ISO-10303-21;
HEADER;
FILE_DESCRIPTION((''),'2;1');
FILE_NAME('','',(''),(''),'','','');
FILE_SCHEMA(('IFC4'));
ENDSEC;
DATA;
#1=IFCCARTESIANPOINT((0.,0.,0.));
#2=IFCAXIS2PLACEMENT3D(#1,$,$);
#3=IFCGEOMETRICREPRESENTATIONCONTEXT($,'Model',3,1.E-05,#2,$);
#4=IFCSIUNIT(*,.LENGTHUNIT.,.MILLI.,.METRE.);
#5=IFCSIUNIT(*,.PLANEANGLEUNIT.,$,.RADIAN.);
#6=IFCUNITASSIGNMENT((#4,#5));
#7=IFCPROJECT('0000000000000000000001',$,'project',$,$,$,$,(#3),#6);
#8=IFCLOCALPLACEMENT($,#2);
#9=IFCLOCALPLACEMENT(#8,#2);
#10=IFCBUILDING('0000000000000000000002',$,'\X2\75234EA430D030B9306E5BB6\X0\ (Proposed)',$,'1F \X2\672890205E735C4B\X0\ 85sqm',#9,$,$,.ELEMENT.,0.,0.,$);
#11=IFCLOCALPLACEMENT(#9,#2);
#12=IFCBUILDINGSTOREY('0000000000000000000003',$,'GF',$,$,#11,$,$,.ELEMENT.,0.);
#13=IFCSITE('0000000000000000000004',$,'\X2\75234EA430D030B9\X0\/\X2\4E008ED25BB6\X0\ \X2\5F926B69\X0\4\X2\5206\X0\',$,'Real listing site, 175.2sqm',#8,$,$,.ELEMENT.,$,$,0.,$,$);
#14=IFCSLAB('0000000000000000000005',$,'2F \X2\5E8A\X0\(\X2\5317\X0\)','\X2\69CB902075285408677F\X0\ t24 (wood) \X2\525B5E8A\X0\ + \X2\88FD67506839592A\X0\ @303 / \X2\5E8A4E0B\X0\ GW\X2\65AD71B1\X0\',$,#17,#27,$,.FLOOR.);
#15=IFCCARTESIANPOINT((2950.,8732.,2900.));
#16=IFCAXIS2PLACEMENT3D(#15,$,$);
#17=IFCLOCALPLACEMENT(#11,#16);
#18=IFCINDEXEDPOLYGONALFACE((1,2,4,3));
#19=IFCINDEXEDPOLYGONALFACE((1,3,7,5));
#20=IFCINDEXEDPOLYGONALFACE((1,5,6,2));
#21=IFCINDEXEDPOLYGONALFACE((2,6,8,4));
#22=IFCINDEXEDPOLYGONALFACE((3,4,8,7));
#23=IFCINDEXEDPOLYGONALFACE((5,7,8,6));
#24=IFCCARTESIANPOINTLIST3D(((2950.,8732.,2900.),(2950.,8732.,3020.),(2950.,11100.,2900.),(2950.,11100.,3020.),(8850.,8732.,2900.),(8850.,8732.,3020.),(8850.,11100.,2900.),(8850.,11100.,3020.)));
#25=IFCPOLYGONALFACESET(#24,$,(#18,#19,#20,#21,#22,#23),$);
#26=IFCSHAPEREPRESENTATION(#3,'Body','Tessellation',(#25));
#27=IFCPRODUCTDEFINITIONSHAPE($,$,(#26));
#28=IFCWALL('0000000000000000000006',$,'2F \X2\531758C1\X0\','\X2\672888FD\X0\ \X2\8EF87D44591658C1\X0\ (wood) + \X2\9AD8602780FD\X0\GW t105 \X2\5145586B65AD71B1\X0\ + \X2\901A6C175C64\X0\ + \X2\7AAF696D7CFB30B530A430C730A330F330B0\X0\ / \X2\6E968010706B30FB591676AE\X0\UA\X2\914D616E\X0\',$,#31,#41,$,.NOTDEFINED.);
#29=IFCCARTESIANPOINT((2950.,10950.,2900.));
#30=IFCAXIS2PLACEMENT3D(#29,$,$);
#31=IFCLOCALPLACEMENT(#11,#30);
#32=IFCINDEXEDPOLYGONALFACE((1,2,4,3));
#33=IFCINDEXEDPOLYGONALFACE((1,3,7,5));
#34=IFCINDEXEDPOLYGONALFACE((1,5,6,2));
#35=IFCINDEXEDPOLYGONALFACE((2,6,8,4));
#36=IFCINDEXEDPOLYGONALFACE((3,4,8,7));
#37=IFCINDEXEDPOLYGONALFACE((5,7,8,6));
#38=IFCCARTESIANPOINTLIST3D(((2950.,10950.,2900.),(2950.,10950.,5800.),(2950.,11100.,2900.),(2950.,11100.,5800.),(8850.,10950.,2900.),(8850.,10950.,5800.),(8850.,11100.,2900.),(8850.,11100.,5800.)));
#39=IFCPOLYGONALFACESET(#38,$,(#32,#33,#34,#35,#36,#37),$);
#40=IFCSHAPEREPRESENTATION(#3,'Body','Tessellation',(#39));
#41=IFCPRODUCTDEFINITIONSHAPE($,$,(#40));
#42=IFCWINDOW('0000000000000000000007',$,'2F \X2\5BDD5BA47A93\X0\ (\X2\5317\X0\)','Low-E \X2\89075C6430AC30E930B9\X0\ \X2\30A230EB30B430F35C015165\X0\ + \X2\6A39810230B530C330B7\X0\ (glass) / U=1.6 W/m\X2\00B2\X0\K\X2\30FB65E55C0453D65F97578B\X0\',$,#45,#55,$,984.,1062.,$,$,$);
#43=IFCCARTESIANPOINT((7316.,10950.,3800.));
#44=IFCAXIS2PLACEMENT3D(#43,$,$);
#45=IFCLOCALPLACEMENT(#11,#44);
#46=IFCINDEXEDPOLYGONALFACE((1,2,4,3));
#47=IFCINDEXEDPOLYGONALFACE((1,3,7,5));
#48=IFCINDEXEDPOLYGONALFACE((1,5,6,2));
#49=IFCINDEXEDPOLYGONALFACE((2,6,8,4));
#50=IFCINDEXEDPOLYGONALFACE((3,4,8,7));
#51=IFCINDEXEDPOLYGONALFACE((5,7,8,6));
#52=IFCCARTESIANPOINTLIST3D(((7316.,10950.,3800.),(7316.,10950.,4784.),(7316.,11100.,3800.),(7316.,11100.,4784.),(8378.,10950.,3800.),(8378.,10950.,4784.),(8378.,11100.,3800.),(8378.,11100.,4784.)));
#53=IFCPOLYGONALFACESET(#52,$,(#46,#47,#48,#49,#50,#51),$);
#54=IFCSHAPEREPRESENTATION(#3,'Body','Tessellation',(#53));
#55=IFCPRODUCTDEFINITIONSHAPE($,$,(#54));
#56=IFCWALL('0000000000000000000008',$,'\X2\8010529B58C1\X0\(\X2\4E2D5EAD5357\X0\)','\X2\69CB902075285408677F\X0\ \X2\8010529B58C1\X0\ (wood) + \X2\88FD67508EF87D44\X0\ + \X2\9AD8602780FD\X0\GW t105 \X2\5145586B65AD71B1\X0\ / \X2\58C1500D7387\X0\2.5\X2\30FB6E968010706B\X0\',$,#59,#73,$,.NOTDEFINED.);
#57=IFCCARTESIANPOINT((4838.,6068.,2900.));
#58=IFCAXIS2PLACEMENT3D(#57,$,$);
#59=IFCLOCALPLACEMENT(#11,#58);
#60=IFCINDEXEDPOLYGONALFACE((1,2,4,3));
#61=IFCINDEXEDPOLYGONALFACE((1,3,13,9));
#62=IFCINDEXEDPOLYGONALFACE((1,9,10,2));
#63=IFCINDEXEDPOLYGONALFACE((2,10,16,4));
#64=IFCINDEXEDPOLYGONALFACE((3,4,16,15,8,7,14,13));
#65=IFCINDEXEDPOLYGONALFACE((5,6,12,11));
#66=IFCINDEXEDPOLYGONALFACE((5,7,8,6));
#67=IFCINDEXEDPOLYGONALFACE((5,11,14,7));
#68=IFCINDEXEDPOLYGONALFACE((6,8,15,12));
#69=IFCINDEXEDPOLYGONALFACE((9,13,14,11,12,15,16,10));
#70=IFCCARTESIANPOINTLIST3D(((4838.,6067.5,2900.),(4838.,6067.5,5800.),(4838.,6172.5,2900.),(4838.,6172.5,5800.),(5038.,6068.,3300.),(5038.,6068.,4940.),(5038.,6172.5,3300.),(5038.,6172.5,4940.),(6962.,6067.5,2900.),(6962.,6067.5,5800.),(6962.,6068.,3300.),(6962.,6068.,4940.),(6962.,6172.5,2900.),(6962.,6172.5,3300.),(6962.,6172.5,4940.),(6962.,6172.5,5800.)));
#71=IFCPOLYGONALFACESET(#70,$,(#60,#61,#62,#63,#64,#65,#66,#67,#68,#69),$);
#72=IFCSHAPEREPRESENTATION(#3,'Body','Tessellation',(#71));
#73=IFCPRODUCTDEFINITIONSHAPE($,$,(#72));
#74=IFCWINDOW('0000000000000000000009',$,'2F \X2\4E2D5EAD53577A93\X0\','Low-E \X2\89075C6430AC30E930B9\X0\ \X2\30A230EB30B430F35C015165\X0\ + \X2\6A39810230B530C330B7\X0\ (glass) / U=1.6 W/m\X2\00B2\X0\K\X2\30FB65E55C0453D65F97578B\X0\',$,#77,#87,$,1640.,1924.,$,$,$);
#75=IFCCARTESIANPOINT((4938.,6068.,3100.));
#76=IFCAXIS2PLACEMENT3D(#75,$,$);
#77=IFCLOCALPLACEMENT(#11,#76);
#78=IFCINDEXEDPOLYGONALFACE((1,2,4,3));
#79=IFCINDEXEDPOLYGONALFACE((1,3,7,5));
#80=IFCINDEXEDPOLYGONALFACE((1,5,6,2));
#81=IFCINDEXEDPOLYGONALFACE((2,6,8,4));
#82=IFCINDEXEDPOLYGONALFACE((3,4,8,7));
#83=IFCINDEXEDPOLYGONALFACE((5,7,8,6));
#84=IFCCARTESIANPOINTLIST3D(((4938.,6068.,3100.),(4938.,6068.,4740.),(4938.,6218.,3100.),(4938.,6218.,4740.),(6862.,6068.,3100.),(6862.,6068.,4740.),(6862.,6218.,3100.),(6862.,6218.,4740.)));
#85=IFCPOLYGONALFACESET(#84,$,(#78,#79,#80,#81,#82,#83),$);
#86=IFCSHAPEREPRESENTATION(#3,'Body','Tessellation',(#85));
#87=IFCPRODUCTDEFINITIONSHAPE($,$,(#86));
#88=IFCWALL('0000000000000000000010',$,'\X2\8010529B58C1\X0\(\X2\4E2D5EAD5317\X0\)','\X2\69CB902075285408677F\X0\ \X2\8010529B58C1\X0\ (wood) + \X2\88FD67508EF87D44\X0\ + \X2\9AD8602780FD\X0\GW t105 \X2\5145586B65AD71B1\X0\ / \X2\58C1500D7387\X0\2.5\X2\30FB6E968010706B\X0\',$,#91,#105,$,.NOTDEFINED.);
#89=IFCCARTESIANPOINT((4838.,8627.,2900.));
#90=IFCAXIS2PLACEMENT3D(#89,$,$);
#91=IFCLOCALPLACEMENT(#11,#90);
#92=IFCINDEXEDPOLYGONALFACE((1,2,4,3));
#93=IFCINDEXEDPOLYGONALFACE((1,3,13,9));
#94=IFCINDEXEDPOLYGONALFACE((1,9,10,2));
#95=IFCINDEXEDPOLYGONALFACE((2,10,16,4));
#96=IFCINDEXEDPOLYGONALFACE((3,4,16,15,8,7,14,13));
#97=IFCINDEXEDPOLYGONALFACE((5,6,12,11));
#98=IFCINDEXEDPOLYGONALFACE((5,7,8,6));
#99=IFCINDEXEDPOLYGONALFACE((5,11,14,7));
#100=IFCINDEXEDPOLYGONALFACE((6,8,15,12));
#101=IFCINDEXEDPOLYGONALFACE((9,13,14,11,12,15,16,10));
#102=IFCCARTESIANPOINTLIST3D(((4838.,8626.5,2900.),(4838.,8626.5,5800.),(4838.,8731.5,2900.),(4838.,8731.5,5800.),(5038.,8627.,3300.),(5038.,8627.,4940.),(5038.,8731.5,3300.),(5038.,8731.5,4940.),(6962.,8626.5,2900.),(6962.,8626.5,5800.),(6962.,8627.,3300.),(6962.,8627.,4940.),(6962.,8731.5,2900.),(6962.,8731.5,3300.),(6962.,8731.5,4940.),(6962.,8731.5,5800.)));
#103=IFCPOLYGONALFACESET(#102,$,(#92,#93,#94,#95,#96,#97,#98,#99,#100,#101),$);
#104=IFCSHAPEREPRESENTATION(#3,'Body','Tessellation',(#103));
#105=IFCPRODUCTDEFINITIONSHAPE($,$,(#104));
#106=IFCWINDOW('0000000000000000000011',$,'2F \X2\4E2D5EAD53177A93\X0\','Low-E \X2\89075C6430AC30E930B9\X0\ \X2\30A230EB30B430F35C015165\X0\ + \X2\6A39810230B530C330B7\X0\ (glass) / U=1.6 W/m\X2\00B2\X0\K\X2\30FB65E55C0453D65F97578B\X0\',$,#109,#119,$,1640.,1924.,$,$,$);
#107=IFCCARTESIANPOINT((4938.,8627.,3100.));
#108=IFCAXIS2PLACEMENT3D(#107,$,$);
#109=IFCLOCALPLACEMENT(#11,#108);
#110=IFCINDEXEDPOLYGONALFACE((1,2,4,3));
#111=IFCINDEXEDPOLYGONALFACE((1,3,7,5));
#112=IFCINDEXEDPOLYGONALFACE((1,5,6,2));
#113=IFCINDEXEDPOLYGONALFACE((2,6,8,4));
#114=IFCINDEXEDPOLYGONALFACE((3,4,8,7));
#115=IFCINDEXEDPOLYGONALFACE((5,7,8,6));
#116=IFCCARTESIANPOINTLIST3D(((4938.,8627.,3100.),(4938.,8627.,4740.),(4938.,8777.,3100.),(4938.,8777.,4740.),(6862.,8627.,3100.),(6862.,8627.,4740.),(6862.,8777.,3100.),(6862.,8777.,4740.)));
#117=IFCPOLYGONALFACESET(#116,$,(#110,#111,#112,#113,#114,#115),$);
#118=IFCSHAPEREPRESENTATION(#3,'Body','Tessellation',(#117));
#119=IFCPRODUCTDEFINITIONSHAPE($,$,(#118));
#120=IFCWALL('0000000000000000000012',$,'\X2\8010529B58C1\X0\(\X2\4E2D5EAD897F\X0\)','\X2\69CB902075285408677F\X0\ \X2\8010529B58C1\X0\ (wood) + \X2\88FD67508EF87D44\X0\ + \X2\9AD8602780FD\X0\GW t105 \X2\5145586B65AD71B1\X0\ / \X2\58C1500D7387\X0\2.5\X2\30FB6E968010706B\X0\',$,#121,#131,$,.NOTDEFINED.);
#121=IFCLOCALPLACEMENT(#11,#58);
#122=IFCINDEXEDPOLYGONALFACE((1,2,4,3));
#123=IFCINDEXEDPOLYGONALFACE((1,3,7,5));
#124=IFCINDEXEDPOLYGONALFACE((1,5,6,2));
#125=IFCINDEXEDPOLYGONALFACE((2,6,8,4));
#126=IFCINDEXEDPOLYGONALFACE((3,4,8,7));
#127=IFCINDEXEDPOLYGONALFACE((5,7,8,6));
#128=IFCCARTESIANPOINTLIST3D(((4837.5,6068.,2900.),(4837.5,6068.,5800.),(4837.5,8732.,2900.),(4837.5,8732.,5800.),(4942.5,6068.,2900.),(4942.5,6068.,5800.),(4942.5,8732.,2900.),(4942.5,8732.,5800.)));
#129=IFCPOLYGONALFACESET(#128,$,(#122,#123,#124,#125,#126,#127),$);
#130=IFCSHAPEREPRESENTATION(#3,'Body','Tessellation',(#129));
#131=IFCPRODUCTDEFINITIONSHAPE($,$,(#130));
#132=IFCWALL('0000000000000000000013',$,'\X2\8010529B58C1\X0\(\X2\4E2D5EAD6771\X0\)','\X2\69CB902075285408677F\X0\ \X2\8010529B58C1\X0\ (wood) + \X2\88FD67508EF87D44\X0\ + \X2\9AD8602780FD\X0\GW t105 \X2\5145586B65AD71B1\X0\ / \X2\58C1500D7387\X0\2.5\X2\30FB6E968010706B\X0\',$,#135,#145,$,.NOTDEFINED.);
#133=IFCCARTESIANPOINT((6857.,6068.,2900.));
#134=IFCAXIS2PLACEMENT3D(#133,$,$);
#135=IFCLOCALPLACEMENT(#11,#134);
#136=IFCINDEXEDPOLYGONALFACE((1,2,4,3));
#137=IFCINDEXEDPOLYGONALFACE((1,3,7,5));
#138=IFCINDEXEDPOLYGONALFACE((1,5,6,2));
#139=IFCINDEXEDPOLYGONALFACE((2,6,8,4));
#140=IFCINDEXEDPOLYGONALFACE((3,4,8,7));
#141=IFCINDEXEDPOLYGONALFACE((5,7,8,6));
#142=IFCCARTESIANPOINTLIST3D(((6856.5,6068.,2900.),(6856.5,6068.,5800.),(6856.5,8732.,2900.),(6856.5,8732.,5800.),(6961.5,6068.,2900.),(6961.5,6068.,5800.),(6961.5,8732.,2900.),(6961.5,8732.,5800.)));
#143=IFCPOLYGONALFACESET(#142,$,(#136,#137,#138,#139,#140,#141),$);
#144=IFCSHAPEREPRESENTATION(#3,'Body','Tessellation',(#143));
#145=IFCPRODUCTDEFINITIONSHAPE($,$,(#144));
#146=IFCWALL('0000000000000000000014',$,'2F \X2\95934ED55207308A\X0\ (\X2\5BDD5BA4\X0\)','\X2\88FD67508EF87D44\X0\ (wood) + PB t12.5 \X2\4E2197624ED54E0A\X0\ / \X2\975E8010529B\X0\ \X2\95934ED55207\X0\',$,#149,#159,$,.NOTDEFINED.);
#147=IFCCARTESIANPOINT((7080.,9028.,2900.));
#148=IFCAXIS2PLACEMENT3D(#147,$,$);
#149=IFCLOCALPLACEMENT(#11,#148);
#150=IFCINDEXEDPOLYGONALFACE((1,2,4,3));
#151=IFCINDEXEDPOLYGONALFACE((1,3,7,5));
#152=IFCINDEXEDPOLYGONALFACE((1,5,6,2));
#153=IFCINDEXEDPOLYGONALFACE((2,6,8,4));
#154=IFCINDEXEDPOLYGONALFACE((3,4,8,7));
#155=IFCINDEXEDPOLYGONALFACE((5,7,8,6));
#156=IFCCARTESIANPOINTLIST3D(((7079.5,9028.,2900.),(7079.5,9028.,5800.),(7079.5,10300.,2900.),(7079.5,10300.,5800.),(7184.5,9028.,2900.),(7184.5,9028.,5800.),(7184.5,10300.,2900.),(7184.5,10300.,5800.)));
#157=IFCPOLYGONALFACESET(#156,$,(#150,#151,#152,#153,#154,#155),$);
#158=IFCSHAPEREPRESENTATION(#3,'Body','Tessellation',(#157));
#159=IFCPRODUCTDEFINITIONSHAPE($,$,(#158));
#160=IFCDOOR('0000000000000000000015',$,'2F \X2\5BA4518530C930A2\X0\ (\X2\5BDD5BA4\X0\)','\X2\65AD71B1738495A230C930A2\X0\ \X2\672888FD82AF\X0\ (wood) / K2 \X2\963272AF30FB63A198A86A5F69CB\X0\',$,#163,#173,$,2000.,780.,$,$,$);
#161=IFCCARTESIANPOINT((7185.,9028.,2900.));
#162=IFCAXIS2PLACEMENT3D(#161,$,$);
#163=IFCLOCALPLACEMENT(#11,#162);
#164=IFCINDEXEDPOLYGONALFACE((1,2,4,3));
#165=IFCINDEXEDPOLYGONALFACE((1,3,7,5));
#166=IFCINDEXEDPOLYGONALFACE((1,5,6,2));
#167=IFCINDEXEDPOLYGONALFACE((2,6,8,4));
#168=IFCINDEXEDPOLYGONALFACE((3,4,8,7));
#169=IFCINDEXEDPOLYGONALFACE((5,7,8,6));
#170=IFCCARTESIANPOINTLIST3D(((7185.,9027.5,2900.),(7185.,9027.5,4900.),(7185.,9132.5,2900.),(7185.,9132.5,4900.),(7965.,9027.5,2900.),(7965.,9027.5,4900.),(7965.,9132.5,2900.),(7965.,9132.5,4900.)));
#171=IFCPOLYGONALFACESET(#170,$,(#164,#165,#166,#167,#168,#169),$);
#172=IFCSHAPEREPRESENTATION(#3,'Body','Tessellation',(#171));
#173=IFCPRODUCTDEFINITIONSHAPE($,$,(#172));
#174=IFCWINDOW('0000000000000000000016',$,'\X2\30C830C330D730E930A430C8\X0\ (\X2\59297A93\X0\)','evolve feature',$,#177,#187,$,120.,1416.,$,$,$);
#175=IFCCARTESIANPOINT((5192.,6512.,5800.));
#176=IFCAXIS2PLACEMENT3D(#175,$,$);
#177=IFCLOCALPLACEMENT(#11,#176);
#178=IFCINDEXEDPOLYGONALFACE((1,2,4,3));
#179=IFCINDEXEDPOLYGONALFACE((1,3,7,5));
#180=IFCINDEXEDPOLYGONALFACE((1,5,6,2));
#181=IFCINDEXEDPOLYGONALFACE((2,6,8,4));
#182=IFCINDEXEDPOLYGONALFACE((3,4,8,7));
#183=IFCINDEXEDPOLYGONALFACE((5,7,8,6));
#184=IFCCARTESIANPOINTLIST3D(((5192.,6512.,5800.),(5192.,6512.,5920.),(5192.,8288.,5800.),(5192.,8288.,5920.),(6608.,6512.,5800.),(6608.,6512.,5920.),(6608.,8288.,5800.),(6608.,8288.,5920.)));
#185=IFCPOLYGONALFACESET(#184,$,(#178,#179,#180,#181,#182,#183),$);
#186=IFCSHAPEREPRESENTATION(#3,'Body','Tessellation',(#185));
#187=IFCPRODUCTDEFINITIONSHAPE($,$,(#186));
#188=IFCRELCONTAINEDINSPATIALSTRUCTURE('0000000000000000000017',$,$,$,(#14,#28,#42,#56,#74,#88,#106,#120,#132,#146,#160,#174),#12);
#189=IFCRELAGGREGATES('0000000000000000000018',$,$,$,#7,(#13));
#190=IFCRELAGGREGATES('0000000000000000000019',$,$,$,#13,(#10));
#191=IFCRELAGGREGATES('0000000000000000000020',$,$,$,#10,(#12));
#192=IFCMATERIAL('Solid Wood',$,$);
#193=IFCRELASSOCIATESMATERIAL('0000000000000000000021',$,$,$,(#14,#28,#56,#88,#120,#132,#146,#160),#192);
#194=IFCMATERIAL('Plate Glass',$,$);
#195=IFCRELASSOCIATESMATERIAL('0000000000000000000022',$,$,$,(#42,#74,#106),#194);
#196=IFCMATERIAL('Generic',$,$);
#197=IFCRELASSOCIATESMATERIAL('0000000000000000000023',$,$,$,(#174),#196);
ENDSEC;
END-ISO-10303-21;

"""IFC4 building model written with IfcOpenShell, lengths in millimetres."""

from ifc_helpers import new_model, si_unit, frame, frame_2d, origin, place, context, project, spatial, rectangle, extrude, material, element, fill, save


model = new_model("IFC4")

# Units and contexts
model_context = context("Model", 3, precision=1e-05, world=origin())
ifc_project = project(units=[si_unit("LENGTHUNIT", "METRE", prefix="MILLI"), si_unit("PLANEANGLEUNIT", "RADIAN")], contexts=[model_context])

# Site, building, storey
site_placement = place(None, origin())
site = spatial("IfcSite", under=ifc_project, at=site_placement, Name="産交バス/一軒家 徒歩4分", ObjectType="Real listing site, 175.2sqm", CompositionType="ELEMENT", RefElevation=0.0)
building_placement = place(site_placement, origin())
building = spatial("IfcBuilding", under=site, at=building_placement, Name="産交バスの家 (Proposed)", ObjectType="1F 木造平屋 85sqm", CompositionType="ELEMENT", ElevationOfRefHeight=0.0, ElevationOfTerrain=0.0)
storey_placement = place(building_placement, origin())
storey = spatial("IfcBuildingStorey", under=building, at=storey_placement, Name="GF", CompositionType="ELEMENT", Elevation=0.0)

# Slab
ifc_material_1 = material(Name="Solid Wood")
slab_placement = place(storey_placement, frame((2950.0, 8732.0, 2900.0)))
element("IfcSlab", 1, at=slab_placement, inside=storey, material=ifc_material_1, Name="2F 床(北)", Description="構造用合板 t24 (wood) 剛床 + 製材根太 @303 / 床下 GW断熱", PredefinedType="FLOOR", context=model_context, shape_type="SweptSolid", body=[
    extrude(rectangle(XDim=5900.0, YDim=2368.0, at=frame_2d((2950.0, 1184.0))), frame((2950.0, 8732.0, 2900.0)), (0.0, 0.0, 1.0), 120.0),
])

# Walls, openings, windows
wall_1_placement = place(storey_placement, frame((2950.0, 10950.0, 2900.0)))
wall_1 = element("IfcWall", 2, at=wall_1_placement, inside=storey, material=ifc_material_1, Name="2F 北壁", Description="木製 軸組外壁 (wood) + 高性能GW t105 充填断熱 + 通気層 + 窯業系サイディング / 準耐火・外皮UA配慮", PredefinedType="NOTDEFINED", context=model_context, shape_type="SweptSolid", body=[
    extrude(rectangle(XDim=5900.0, YDim=150.0, at=frame_2d((2950.0, 75.0))), frame((2950.0, 10950.0, 2900.0)), (0.0, 0.0, 1.0), 2900.0),
])
opening_1_placement = place(storey_placement, frame((7316.0, 10950.0, 3800.0)))
opening_1 = element("IfcOpeningElement", 3, at=opening_1_placement, cuts=wall_1, PredefinedType="NOTDEFINED", context=model_context, shape_type="SweptSolid", body=[
    extrude(rectangle(XDim=1062.0, YDim=150.0, at=frame_2d((531.0, 75.0))), frame((7316.0, 10950.0, 3800.0)), (0.0, 0.0, 1.0), 984.0),
])
ifc_material_2 = material(Name="Plate Glass")
window_1_placement = place(storey_placement, frame((7316.0, 10950.0, 3800.0)))
window_1 = element("IfcWindow", 4, at=window_1_placement, inside=storey, material=ifc_material_2, Name="2F 寝室窓 (北)", Description="Low-E 複層ガラス アルゴン封入 + 樹脂サッシ (glass) / U=1.6 W/m²K・日射取得型", OverallHeight=984.0, OverallWidth=1062.0, context=model_context, shape_type="SweptSolid", body=[
    extrude(rectangle(XDim=1062.0, YDim=150.0, at=frame_2d((531.0, 75.0))), frame((7316.0, 10950.0, 3800.0)), (0.0, 0.0, 1.0), 984.0),
])
fill(opening_1, window_1)
wall_2_placement = place(storey_placement, frame((4838.0, 6068.0, 2900.0)))
wall_2 = element("IfcWall", 5, at=wall_2_placement, inside=storey, material=ifc_material_1, Name="耐力壁(中庭南)", Description="構造用合板 耐力壁 (wood) + 製材軸組 + 高性能GW t105 充填断熱 / 壁倍率2.5・準耐火", PredefinedType="NOTDEFINED", context=model_context, shape_type="SweptSolid", body=[
    extrude(rectangle(XDim=2124.0, YDim=105.0, at=frame_2d((1062.0, 52.0))), frame((4838.0, 6068.0, 2900.0)), (0.0, 0.0, 1.0), 2900.0),
])
opening_2_placement = place(storey_placement, frame((4938.0, 6068.0, 3100.0)))
opening_2 = element("IfcOpeningElement", 6, at=opening_2_placement, cuts=wall_2, PredefinedType="NOTDEFINED", context=model_context, shape_type="SweptSolid", body=[
    extrude(rectangle(XDim=1924.0, YDim=150.0, at=frame_2d((962.0, 75.0))), frame((4938.0, 6068.0, 3100.0)), (0.0, 0.0, 1.0), 1640.0),
])
window_2_placement = place(storey_placement, frame((4938.0, 6068.0, 3100.0)))
window_2 = element("IfcWindow", 7, at=window_2_placement, inside=storey, material=ifc_material_2, Name="2F 中庭南窓", Description="Low-E 複層ガラス アルゴン封入 + 樹脂サッシ (glass) / U=1.6 W/m²K・日射取得型", OverallHeight=1640.0, OverallWidth=1924.0, context=model_context, shape_type="SweptSolid", body=[
    extrude(rectangle(XDim=1924.0, YDim=150.0, at=frame_2d((962.0, 75.0))), frame((4938.0, 6068.0, 3100.0)), (0.0, 0.0, 1.0), 1640.0),
])
fill(opening_2, window_2)
wall_3_placement = place(storey_placement, frame((4838.0, 8627.0, 2900.0)))
wall_3 = element("IfcWall", 8, at=wall_3_placement, inside=storey, material=ifc_material_1, Name="耐力壁(中庭北)", Description="構造用合板 耐力壁 (wood) + 製材軸組 + 高性能GW t105 充填断熱 / 壁倍率2.5・準耐火", PredefinedType="NOTDEFINED", context=model_context, shape_type="SweptSolid", body=[
    extrude(rectangle(XDim=2124.0, YDim=105.0, at=frame_2d((1062.0, 52.0))), frame((4838.0, 8627.0, 2900.0)), (0.0, 0.0, 1.0), 2900.0),
])
opening_3_placement = place(storey_placement, frame((4938.0, 8627.0, 3100.0)))
opening_3 = element("IfcOpeningElement", 9, at=opening_3_placement, cuts=wall_3, PredefinedType="NOTDEFINED", context=model_context, shape_type="SweptSolid", body=[
    extrude(rectangle(XDim=1924.0, YDim=150.0, at=frame_2d((962.0, 75.0))), frame((4938.0, 8627.0, 3100.0)), (0.0, 0.0, 1.0), 1640.0),
])
window_3_placement = place(storey_placement, frame((4938.0, 8627.0, 3100.0)))
window_3 = element("IfcWindow", 10, at=window_3_placement, inside=storey, material=ifc_material_2, Name="2F 中庭北窓", Description="Low-E 複層ガラス アルゴン封入 + 樹脂サッシ (glass) / U=1.6 W/m²K・日射取得型", OverallHeight=1640.0, OverallWidth=1924.0, context=model_context, shape_type="SweptSolid", body=[
    extrude(rectangle(XDim=1924.0, YDim=150.0, at=frame_2d((962.0, 75.0))), frame((4938.0, 8627.0, 3100.0)), (0.0, 0.0, 1.0), 1640.0),
])
fill(opening_3, window_3)

# Walls
wall_4_placement = place(storey_placement, frame((4838.0, 6068.0, 2900.0)))
element("IfcWall", 11, at=wall_4_placement, inside=storey, material=ifc_material_1, Name="耐力壁(中庭西)", Description="構造用合板 耐力壁 (wood) + 製材軸組 + 高性能GW t105 充填断熱 / 壁倍率2.5・準耐火", PredefinedType="NOTDEFINED", context=model_context, shape_type="SweptSolid", body=[
    extrude(rectangle(XDim=105.0, YDim=2664.0, at=frame_2d((52.0, 1332.0))), frame((4838.0, 6068.0, 2900.0)), (0.0, 0.0, 1.0), 2900.0),
])
wall_5_placement = place(storey_placement, frame((6857.0, 6068.0, 2900.0)))
element("IfcWall", 12, at=wall_5_placement, inside=storey, material=ifc_material_1, Name="耐力壁(中庭東)", Description="構造用合板 耐力壁 (wood) + 製材軸組 + 高性能GW t105 充填断熱 / 壁倍率2.5・準耐火", PredefinedType="NOTDEFINED", context=model_context, shape_type="SweptSolid", body=[
    extrude(rectangle(XDim=105.0, YDim=2664.0, at=frame_2d((52.0, 1332.0))), frame((6857.0, 6068.0, 2900.0)), (0.0, 0.0, 1.0), 2900.0),
])
wall_6_placement = place(storey_placement, frame((7080.0, 9028.0, 2900.0)))
element("IfcWall", 13, at=wall_6_placement, inside=storey, material=ifc_material_1, Name="2F 間仕切り (寝室)", Description="製材軸組 (wood) + PB t12.5 両面仕上 / 非耐力 間仕切", PredefinedType="NOTDEFINED", context=model_context, shape_type="SweptSolid", body=[
    extrude(rectangle(XDim=105.0, YDim=1272.0, at=frame_2d((52.0, 636.0))), frame((7080.0, 9028.0, 2900.0)), (0.0, 0.0, 1.0), 2900.0),
])

# Door
door_placement = place(storey_placement, frame((7185.0, 9028.0, 2900.0)))
element("IfcDoor", 14, at=door_placement, inside=storey, material=ifc_material_1, Name="2F 室内ドア (寝室)", Description="断熱玄関ドア 木製芯 (wood) / K2 防犯・採風機構", OverallHeight=2000.0, OverallWidth=780.0, context=model_context, shape_type="SweptSolid", body=[
    extrude(rectangle(XDim=780.0, YDim=105.0, at=frame_2d((390.0, 52.0))), frame((7185.0, 9028.0, 2900.0)), (0.0, 0.0, 1.0), 2000.0),
])

# Window
ifc_material_3 = material(Name="Generic")
window_4_placement = place(storey_placement, frame((5192.0, 6512.0, 5800.0)))
element("IfcWindow", 15, at=window_4_placement, inside=storey, material=ifc_material_3, Name="トップライト (天窓)", Description="evolve feature", OverallHeight=120.0, OverallWidth=1416.0, context=model_context, shape_type="SweptSolid", body=[
    extrude(rectangle(XDim=1416.0, YDim=1776.0, at=frame_2d((708.0, 888.0))), frame((5192.0, 6512.0, 5800.0)), (0.0, 0.0, 1.0), 120.0),
])

save(model, "model.ifc")
